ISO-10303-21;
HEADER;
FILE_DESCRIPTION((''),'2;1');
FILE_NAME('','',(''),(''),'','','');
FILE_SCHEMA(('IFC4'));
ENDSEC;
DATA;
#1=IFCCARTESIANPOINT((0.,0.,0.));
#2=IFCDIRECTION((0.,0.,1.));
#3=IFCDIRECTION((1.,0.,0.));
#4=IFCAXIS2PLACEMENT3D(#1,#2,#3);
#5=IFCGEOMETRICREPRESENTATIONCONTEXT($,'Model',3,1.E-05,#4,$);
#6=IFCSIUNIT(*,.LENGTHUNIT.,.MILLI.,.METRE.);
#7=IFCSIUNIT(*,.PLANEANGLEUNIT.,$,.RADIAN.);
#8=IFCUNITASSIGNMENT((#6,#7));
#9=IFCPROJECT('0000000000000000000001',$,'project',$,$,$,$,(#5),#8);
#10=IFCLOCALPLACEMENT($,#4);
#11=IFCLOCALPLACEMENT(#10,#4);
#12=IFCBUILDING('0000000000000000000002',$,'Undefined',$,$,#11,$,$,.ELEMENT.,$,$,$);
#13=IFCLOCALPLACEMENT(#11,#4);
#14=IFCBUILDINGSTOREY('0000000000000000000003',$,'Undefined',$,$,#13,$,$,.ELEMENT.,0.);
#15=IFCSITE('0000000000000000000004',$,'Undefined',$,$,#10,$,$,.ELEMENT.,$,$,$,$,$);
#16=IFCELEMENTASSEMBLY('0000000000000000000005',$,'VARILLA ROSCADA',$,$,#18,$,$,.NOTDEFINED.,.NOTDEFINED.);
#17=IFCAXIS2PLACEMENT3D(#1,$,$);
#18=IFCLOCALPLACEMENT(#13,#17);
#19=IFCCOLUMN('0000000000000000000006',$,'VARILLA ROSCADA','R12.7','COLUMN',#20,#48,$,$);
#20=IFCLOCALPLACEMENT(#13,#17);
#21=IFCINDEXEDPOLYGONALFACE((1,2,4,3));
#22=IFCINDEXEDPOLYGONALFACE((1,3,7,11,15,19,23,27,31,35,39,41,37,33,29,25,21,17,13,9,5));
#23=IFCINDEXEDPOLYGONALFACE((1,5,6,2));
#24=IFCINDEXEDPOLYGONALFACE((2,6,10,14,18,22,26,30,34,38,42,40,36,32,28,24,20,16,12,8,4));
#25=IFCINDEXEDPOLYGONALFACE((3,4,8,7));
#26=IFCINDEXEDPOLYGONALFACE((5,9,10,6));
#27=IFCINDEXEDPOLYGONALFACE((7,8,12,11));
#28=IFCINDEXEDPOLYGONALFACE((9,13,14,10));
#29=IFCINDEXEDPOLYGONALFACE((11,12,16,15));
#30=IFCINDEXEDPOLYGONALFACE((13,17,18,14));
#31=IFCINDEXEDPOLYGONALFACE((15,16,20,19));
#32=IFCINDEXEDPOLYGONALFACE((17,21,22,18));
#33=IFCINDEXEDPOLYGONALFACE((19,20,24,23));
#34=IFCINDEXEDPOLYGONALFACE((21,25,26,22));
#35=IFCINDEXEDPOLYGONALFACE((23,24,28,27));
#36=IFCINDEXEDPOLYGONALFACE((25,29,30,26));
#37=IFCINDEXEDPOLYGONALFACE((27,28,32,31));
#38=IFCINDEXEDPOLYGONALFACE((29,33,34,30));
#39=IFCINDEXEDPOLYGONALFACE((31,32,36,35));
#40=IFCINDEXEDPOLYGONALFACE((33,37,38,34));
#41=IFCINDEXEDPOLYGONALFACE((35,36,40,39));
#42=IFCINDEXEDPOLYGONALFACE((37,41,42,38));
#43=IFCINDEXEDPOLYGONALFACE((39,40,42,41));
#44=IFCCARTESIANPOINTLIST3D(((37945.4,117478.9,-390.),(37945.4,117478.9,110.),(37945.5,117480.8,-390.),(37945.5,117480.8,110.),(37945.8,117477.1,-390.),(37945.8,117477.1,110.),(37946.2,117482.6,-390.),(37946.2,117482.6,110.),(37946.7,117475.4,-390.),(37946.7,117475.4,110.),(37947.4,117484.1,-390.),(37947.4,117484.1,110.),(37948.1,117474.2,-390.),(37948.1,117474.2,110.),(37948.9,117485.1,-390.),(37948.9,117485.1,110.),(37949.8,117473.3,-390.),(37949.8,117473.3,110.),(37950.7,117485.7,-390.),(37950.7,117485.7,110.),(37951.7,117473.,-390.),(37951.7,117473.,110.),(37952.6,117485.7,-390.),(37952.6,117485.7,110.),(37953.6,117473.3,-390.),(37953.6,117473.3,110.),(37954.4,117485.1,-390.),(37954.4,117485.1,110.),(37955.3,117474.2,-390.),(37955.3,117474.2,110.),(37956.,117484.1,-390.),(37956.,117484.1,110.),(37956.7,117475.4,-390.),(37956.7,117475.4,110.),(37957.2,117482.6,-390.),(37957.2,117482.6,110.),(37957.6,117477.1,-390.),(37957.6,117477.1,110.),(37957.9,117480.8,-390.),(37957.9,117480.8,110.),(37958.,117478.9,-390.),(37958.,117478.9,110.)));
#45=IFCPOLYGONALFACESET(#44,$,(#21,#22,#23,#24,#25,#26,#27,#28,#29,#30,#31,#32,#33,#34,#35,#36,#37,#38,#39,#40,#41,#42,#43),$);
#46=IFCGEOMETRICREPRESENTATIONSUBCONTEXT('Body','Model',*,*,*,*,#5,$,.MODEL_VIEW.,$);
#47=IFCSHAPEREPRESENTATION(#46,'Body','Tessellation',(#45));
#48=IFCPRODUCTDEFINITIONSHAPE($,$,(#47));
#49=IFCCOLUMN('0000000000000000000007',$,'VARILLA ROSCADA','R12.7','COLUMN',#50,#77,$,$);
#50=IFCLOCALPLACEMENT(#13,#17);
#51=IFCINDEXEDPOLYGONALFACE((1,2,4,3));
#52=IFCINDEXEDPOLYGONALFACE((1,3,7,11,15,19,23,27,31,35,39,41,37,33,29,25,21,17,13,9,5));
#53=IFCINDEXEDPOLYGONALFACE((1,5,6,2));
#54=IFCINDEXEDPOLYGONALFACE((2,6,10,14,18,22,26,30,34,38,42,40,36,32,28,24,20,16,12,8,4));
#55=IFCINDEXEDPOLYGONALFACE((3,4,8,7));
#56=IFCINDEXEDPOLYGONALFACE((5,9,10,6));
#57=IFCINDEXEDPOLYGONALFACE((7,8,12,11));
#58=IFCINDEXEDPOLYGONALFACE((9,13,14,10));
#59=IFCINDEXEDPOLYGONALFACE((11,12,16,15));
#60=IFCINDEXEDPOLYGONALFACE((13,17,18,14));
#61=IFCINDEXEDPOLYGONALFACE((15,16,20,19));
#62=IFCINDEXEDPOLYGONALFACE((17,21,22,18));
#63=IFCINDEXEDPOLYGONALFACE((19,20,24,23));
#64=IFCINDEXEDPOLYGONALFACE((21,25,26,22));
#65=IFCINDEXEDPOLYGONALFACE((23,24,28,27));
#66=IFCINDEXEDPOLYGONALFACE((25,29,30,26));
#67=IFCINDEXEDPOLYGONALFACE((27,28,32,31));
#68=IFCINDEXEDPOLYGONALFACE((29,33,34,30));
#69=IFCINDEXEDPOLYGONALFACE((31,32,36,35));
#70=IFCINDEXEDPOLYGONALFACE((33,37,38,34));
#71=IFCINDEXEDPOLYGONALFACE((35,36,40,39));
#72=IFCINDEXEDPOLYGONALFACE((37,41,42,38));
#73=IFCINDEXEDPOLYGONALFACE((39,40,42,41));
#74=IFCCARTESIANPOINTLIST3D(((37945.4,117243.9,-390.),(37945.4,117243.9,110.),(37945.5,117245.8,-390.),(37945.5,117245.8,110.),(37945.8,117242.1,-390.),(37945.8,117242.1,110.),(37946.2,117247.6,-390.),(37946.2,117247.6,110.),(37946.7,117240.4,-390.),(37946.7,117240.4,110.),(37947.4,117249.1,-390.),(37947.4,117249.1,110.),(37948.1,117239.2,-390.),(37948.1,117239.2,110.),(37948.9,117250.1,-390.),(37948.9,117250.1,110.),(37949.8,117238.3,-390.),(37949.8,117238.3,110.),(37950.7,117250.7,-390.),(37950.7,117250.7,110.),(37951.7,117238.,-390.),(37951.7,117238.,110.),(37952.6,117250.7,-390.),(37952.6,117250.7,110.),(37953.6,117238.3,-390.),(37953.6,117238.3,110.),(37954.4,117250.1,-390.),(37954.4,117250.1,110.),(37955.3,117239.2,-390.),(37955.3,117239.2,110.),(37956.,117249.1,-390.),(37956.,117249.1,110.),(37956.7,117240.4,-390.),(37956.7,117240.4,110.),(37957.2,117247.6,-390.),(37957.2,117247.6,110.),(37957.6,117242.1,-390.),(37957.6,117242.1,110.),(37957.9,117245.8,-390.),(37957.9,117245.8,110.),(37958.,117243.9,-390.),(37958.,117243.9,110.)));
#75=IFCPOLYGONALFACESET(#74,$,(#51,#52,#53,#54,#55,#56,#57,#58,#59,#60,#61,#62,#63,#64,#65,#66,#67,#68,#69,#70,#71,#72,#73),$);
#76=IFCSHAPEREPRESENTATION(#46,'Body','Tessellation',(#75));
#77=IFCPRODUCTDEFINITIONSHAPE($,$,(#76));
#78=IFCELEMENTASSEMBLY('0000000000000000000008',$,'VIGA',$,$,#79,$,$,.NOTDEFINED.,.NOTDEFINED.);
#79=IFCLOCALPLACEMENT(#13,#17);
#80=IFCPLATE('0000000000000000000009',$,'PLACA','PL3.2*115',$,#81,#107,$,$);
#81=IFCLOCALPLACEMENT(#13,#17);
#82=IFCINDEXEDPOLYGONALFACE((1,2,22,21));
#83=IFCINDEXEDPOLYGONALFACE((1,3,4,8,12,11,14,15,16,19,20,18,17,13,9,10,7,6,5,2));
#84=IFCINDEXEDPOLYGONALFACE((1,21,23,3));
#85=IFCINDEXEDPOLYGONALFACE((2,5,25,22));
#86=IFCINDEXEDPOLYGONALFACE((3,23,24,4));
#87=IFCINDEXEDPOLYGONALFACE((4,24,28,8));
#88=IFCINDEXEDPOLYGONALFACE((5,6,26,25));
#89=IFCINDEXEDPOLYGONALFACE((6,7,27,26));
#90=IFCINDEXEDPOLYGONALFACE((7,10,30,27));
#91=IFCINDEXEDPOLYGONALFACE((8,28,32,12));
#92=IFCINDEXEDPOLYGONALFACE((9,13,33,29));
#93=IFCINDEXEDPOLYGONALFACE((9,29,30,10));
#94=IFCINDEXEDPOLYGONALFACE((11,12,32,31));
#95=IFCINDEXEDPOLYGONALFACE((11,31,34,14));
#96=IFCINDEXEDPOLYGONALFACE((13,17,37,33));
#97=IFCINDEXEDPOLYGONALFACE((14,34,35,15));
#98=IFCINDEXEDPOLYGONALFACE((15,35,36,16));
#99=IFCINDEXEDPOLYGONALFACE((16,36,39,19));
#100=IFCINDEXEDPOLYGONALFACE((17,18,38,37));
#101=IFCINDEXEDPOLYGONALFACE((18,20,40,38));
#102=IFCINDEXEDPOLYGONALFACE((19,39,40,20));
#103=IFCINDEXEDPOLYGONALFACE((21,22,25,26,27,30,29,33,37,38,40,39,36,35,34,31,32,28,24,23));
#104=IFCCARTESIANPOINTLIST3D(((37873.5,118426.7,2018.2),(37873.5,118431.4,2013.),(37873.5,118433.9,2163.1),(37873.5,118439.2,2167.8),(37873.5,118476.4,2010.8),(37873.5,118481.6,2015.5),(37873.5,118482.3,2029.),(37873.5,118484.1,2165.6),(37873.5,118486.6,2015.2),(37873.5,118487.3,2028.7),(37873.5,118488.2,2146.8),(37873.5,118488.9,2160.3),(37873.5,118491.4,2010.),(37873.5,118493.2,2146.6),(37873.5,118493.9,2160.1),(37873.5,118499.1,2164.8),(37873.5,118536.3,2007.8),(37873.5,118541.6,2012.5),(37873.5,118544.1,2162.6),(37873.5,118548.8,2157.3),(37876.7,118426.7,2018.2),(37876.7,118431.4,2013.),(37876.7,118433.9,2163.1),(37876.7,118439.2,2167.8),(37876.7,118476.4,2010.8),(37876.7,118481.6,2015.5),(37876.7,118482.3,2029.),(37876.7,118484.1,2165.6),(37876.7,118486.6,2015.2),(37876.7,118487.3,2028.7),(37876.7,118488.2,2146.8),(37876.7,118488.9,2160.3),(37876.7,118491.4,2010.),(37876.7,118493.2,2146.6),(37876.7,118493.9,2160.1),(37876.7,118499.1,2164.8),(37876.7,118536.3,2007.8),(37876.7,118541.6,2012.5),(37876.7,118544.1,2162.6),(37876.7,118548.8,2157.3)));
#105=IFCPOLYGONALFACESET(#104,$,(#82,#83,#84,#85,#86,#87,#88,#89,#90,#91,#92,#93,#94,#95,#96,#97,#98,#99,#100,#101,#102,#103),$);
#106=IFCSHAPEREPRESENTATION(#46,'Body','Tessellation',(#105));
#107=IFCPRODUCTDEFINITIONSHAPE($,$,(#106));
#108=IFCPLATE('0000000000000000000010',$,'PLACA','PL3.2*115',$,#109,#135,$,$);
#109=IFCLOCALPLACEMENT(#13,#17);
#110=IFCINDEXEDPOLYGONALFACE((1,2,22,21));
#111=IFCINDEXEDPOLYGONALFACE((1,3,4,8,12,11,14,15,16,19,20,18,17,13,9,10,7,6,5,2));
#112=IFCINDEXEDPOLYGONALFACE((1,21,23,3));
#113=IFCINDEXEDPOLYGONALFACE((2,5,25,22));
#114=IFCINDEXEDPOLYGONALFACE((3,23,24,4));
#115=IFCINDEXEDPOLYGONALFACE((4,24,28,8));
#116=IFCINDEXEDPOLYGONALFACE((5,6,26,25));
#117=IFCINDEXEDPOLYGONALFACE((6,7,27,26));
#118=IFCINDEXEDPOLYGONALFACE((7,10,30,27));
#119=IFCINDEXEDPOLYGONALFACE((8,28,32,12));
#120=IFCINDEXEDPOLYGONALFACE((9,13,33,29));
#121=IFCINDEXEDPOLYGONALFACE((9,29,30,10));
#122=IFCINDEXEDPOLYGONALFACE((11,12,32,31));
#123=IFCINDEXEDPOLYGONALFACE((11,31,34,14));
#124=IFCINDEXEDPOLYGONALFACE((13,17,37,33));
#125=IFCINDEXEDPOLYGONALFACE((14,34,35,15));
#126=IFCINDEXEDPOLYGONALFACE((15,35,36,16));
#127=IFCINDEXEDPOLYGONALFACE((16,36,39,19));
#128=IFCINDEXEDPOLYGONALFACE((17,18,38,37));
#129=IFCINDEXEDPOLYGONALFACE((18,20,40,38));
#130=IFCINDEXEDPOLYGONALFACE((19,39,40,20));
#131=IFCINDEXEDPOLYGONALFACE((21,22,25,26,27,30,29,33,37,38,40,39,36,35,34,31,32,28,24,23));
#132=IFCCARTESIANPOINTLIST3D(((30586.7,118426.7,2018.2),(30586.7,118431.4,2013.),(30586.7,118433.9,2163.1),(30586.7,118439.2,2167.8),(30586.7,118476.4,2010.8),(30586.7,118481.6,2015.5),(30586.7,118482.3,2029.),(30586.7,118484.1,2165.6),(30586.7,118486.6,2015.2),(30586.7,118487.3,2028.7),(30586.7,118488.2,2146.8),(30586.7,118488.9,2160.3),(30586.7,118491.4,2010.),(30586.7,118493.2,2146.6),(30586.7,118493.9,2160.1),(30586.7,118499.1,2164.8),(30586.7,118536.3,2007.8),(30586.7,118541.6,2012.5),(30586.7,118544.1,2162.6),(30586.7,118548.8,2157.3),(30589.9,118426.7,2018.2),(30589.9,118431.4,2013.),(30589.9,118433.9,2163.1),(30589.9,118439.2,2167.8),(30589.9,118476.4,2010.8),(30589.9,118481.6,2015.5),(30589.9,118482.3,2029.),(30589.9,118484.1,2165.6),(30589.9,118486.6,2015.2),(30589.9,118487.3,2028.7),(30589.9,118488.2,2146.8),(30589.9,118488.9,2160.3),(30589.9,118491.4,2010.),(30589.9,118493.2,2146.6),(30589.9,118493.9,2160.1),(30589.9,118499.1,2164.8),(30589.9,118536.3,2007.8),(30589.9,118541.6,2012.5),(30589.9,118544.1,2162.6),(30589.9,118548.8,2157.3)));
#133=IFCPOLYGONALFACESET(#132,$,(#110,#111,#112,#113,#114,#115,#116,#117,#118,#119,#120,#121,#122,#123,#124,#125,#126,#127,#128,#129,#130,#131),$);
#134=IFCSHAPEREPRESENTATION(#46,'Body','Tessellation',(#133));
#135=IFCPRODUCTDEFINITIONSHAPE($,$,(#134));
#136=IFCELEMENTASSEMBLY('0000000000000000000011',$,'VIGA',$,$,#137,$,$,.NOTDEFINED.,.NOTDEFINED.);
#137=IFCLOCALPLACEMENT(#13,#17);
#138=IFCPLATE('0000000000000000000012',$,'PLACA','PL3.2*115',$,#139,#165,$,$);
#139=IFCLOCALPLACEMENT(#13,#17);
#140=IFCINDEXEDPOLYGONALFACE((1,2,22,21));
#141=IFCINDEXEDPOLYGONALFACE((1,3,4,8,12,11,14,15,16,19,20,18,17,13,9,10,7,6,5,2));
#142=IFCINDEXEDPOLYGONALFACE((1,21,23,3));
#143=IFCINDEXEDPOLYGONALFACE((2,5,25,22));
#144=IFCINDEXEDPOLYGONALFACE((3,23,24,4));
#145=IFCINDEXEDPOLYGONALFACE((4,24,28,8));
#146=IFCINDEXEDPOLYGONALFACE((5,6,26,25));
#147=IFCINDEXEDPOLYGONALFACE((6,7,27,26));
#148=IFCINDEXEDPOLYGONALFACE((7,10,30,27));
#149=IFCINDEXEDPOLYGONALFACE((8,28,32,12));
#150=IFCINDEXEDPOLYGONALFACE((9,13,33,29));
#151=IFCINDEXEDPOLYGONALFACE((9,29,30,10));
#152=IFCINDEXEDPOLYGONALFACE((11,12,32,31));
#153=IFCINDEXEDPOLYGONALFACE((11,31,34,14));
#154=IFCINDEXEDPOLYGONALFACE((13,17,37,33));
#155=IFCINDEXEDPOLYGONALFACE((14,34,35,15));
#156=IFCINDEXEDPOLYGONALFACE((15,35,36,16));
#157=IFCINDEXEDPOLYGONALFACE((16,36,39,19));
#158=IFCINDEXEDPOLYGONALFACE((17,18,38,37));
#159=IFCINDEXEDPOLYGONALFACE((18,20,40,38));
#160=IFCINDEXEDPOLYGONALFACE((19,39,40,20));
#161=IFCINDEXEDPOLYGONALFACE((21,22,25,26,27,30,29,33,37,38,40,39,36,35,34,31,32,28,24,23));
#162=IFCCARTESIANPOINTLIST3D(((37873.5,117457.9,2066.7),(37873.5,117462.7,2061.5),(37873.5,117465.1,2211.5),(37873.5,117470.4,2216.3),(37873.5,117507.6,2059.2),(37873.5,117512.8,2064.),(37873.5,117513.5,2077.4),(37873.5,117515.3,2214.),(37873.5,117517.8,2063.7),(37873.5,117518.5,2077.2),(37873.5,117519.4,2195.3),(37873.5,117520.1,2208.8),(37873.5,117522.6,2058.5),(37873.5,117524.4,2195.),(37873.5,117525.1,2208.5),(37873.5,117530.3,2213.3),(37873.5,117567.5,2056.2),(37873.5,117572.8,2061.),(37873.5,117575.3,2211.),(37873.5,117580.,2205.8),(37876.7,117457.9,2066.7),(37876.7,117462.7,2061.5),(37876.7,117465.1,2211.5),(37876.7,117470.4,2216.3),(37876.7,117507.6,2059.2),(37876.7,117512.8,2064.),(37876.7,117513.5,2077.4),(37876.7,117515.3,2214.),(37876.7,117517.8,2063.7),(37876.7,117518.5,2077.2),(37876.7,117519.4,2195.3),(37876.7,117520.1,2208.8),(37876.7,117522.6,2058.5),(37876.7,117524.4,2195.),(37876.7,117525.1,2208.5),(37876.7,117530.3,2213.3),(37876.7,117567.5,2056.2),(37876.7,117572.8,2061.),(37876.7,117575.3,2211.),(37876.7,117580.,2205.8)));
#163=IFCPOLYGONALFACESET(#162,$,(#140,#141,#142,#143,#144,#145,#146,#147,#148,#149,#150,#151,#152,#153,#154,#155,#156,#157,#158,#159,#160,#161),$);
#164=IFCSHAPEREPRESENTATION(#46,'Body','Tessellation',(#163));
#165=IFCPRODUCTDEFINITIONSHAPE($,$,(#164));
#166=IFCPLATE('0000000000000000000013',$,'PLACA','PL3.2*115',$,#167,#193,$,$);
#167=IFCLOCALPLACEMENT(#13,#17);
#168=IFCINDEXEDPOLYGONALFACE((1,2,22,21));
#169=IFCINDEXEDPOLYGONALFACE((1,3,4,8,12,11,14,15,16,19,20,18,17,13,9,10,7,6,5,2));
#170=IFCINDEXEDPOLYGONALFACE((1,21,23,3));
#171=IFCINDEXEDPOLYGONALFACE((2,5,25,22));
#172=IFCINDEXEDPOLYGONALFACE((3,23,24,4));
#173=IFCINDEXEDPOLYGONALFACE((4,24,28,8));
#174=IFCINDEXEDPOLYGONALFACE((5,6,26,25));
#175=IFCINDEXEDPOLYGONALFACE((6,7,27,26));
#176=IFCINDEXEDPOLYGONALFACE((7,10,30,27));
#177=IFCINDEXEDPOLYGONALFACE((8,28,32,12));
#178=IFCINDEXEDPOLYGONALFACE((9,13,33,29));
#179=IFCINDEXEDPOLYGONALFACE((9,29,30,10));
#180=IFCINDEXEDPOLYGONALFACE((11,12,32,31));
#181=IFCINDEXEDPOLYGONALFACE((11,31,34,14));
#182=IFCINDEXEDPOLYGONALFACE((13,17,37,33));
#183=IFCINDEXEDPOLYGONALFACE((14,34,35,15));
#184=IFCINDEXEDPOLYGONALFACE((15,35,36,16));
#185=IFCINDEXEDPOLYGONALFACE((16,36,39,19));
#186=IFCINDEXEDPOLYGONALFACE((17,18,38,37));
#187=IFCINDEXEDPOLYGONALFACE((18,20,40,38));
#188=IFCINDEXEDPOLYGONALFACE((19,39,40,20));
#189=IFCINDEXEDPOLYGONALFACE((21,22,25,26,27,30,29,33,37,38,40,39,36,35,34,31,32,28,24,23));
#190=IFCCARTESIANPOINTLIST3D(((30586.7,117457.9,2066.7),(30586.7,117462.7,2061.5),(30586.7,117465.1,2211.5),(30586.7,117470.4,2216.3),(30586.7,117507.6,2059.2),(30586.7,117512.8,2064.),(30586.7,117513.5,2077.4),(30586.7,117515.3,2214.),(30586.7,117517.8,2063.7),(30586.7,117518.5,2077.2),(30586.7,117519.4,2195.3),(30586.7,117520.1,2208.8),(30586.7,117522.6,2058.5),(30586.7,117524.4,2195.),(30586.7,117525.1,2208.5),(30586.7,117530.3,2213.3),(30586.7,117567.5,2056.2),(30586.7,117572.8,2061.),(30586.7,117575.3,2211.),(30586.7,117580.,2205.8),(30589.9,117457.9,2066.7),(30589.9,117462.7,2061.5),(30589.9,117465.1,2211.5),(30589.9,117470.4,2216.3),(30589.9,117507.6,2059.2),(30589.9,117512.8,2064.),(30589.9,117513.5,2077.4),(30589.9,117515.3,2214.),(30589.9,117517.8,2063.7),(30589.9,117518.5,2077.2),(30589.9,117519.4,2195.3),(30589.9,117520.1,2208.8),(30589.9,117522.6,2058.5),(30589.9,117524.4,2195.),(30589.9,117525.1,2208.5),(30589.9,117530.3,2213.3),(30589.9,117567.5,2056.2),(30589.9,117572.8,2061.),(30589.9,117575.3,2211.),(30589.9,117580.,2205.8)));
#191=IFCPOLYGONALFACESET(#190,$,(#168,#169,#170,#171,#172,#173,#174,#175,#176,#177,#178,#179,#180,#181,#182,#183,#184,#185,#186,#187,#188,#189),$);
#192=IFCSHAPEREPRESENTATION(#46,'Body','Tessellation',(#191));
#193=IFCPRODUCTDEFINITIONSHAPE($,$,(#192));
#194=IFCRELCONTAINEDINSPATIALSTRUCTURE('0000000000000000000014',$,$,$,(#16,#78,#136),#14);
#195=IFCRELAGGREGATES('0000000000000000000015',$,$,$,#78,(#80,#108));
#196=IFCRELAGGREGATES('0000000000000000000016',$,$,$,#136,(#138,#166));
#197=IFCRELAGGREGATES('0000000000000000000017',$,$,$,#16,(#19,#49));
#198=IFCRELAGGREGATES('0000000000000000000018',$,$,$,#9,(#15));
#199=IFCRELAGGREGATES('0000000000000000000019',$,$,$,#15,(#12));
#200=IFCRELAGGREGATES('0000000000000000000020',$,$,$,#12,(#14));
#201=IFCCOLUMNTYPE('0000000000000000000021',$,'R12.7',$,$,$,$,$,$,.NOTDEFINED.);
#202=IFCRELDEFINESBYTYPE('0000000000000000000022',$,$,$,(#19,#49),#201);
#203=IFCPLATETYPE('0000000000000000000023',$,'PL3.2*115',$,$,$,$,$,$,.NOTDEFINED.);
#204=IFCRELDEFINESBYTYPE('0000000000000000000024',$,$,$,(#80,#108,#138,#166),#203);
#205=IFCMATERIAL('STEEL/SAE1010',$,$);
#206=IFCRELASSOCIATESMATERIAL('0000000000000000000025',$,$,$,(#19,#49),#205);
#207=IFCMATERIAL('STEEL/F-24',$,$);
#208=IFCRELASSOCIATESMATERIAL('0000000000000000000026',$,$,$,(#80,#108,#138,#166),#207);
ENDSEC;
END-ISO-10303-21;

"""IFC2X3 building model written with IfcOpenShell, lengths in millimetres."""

from ifc_helpers import new_model, si_unit, frame, origin_with_axes, origin_2d_with_axis, place, context, subcontext, project, spatial, polyline, circle, outline, extrude, material, type_object, element, aggregate, save


model = new_model("IFC2X3")

# Units and contexts
model_context = context("Model", 3, precision=1e-05, world=origin_with_axes())
body_context = subcontext(model_context, "Body", "Model", "MODEL_VIEW")
ifc_project = project(units=[si_unit("LENGTHUNIT", "METRE", prefix="MILLI"), si_unit("PLANEANGLEUNIT", "RADIAN")], contexts=[model_context])

# Site, building, storey
site_placement = place(None, origin_with_axes())
site = spatial("IfcSite", under=ifc_project, at=site_placement, Name="Undefined", CompositionType="ELEMENT")
building_placement = place(site_placement, origin_with_axes())
building = spatial("IfcBuilding", under=site, at=building_placement, Name="Undefined", CompositionType="ELEMENT")
storey_placement = place(building_placement, origin_with_axes())
storey = spatial("IfcBuildingStorey", under=building, at=storey_placement, Name="Undefined", CompositionType="ELEMENT", Elevation=0.0)

# Element assembly, columns
assembly_1_placement = place(storey_placement, origin_with_axes())
assembly_1 = element("IfcElementAssembly", 1, at=assembly_1_placement, inside=storey, Name="VARILLA ROSCADA", AssemblyPlace="NOTDEFINED", PredefinedType="NOTDEFINED")
ifc_material_1 = material(Name="STEEL/SAE1010")
column_type = type_object("IfcColumnType", Name="R12.7", PredefinedType="NOTDEFINED")
column_1_placement = place(assembly_1_placement, frame((37951.7, 117479.4, -390.0), z_axis=(0.0, 0.0, 1.0), x_axis=(-1.0, 0.0, 0.0)))
column_1 = element("IfcColumn", 2, at=column_1_placement, type_object=column_type, material=ifc_material_1, Name="VARILLA ROSCADA", Description="R12.7", ObjectType="COLUMN", context=body_context, shape_type="SweptSolid", body=[
    extrude(circle(Radius=6.3, at=origin_2d_with_axis()), frame((0.0, 0.0, 500.0), z_axis=(0.0, 0.0, -1.0), x_axis=(0.0, 1.0, 0.0)), (0.0, 0.0, 1.0), 500.0),
])
column_2_placement = place(assembly_1_placement, frame((37951.7, 117244.4, -390.0), z_axis=(0.0, 0.0, 1.0), x_axis=(-1.0, 0.0, 0.0)))
column_2 = element("IfcColumn", 3, at=column_2_placement, type_object=column_type, material=ifc_material_1, Name="VARILLA ROSCADA", Description="R12.7", ObjectType="COLUMN", context=body_context, shape_type="SweptSolid", body=[
    extrude(circle(Radius=6.3, at=origin_2d_with_axis()), frame((0.0, 0.0, 500.0), z_axis=(0.0, 0.0, -1.0), x_axis=(0.0, 1.0, 0.0)), (0.0, 0.0, 1.0), 500.0),
])

# Shared definitions
ifc_material_2 = material(Name="STEEL/F-24")

# Element assemblies, plates
assembly_2_placement = place(storey_placement, origin_with_axes())
assembly_2 = element("IfcElementAssembly", 4, at=assembly_2_placement, inside=storey, Name="VIGA", AssemblyPlace="NOTDEFINED", PredefinedType="NOTDEFINED")
plate_type_1 = type_object("IfcPlateType", Name="PL3.2*115", PredefinedType="NOTDEFINED")
plate_1_placement = place(assembly_2_placement, frame((37875.1, 118549.0, 2162.3), z_axis=(1.0, 0.0, 0.0), x_axis=(0.0, -0.998752, 0.04995)))
plate_1 = element("IfcPlate", 5, at=plate_1_placement, type_object=plate_type_1, material=ifc_material_2, Name="PLACA", Description="PL3.2*115", context=body_context, shape_type="SweptSolid", body=[
    extrude(outline(polyline([(0.0, 5.0), (5.0, 0.0), (50.0, 0.0), (55.0, 5.0), (55.0, 18.5), (60.0, 18.5), (60.0, 5.0), (65.0, 0.0), (110.0, 0.0), (115.0, 5.0), (115.0, 150.0), (110.0, 155.0), (65.0, 155.0), (60.0, 150.0), (60.0, 136.5), (55.0, 136.5), (55.0, 150.0), (50.0, 155.0), (5.0, 155.0), (0.0, 150.0), (0.0, 5.0)])), frame((0.0, 0.0, -1.6), z_axis=(0.0, 0.0, 1.0), x_axis=(1.0, 0.0, 0.0)), (0.0, 0.0, 1.0), 3.2),
])
plate_2_placement = place(assembly_2_placement, frame((30588.3, 118549.0, 2162.3), z_axis=(1.0, 0.0, 0.0), x_axis=(0.0, -0.998752, 0.04995)))
plate_2 = element("IfcPlate", 6, at=plate_2_placement, type_object=plate_type_1, material=ifc_material_2, Name="PLACA", Description="PL3.2*115", context=body_context, shape_type="SweptSolid", body=[
    extrude(outline(polyline([(0.0, 5.0), (5.0, 0.0), (50.0, 0.0), (55.0, 5.0), (55.0, 18.5), (60.0, 18.5), (60.0, 5.0), (65.0, 0.0), (110.0, 0.0), (115.0, 5.0), (115.0, 150.0), (110.0, 155.0), (65.0, 155.0), (60.0, 150.0), (60.0, 136.5), (55.0, 136.5), (55.0, 150.0), (50.0, 155.0), (5.0, 155.0), (0.0, 150.0), (0.0, 5.0)])), frame((0.0, 0.0, -1.6), z_axis=(0.0, 0.0, 1.0), x_axis=(1.0, 0.0, 0.0)), (0.0, 0.0, 1.0), 3.2),
])
assembly_3_placement = place(storey_placement, origin_with_axes())
assembly_3 = element("IfcElementAssembly", 7, at=assembly_3_placement, inside=storey, Name="VIGA", AssemblyPlace="NOTDEFINED", PredefinedType="NOTDEFINED")
plate_3_placement = place(assembly_3_placement, frame((37875.1, 117580.3, 2210.8), z_axis=(1.0, 0.0, 0.0), x_axis=(0.0, -0.998752, 0.04995)))
plate_3 = element("IfcPlate", 8, at=plate_3_placement, type_object=plate_type_1, material=ifc_material_2, Name="PLACA", Description="PL3.2*115", context=body_context, shape_type="SweptSolid", body=[
    extrude(outline(polyline([(0.0, 5.0), (5.0, 0.0), (50.0, 0.0), (55.0, 5.0), (55.0, 18.5), (60.0, 18.5), (60.0, 5.0), (65.0, 0.0), (110.0, 0.0), (115.0, 5.0), (115.0, 150.0), (110.0, 155.0), (65.0, 155.0), (60.0, 150.0), (60.0, 136.5), (55.0, 136.5), (55.0, 150.0), (50.0, 155.0), (5.0, 155.0), (0.0, 150.0), (0.0, 5.0)])), frame((0.0, 0.0, -1.6), z_axis=(0.0, 0.0, 1.0), x_axis=(1.0, 0.0, 0.0)), (0.0, 0.0, 1.0), 3.2),
])
plate_4_placement = place(assembly_3_placement, frame((30588.3, 117580.3, 2210.8), z_axis=(1.0, 0.0, 0.0), x_axis=(0.0, -0.998752, 0.04995)))
plate_4 = element("IfcPlate", 9, at=plate_4_placement, type_object=plate_type_1, material=ifc_material_2, Name="PLACA", Description="PL3.2*115", context=body_context, shape_type="SweptSolid", body=[
    extrude(outline(polyline([(0.0, 5.0), (5.0, 0.0), (50.0, 0.0), (55.0, 5.0), (55.0, 18.5), (60.0, 18.5), (60.0, 5.0), (65.0, 0.0), (110.0, 0.0), (115.0, 5.0), (115.0, 150.0), (110.0, 155.0), (65.0, 155.0), (60.0, 150.0), (60.0, 136.5), (55.0, 136.5), (55.0, 150.0), (50.0, 155.0), (5.0, 155.0), (0.0, 150.0), (0.0, 5.0)])), frame((0.0, 0.0, -1.6), z_axis=(0.0, 0.0, 1.0), x_axis=(1.0, 0.0, 0.0)), (0.0, 0.0, 1.0), 3.2),
])

aggregate(assembly_2, [plate_1, plate_2])
aggregate(assembly_3, [plate_3, plate_4])
aggregate(assembly_1, [column_1, column_2])

save(model, "model.ifc")
